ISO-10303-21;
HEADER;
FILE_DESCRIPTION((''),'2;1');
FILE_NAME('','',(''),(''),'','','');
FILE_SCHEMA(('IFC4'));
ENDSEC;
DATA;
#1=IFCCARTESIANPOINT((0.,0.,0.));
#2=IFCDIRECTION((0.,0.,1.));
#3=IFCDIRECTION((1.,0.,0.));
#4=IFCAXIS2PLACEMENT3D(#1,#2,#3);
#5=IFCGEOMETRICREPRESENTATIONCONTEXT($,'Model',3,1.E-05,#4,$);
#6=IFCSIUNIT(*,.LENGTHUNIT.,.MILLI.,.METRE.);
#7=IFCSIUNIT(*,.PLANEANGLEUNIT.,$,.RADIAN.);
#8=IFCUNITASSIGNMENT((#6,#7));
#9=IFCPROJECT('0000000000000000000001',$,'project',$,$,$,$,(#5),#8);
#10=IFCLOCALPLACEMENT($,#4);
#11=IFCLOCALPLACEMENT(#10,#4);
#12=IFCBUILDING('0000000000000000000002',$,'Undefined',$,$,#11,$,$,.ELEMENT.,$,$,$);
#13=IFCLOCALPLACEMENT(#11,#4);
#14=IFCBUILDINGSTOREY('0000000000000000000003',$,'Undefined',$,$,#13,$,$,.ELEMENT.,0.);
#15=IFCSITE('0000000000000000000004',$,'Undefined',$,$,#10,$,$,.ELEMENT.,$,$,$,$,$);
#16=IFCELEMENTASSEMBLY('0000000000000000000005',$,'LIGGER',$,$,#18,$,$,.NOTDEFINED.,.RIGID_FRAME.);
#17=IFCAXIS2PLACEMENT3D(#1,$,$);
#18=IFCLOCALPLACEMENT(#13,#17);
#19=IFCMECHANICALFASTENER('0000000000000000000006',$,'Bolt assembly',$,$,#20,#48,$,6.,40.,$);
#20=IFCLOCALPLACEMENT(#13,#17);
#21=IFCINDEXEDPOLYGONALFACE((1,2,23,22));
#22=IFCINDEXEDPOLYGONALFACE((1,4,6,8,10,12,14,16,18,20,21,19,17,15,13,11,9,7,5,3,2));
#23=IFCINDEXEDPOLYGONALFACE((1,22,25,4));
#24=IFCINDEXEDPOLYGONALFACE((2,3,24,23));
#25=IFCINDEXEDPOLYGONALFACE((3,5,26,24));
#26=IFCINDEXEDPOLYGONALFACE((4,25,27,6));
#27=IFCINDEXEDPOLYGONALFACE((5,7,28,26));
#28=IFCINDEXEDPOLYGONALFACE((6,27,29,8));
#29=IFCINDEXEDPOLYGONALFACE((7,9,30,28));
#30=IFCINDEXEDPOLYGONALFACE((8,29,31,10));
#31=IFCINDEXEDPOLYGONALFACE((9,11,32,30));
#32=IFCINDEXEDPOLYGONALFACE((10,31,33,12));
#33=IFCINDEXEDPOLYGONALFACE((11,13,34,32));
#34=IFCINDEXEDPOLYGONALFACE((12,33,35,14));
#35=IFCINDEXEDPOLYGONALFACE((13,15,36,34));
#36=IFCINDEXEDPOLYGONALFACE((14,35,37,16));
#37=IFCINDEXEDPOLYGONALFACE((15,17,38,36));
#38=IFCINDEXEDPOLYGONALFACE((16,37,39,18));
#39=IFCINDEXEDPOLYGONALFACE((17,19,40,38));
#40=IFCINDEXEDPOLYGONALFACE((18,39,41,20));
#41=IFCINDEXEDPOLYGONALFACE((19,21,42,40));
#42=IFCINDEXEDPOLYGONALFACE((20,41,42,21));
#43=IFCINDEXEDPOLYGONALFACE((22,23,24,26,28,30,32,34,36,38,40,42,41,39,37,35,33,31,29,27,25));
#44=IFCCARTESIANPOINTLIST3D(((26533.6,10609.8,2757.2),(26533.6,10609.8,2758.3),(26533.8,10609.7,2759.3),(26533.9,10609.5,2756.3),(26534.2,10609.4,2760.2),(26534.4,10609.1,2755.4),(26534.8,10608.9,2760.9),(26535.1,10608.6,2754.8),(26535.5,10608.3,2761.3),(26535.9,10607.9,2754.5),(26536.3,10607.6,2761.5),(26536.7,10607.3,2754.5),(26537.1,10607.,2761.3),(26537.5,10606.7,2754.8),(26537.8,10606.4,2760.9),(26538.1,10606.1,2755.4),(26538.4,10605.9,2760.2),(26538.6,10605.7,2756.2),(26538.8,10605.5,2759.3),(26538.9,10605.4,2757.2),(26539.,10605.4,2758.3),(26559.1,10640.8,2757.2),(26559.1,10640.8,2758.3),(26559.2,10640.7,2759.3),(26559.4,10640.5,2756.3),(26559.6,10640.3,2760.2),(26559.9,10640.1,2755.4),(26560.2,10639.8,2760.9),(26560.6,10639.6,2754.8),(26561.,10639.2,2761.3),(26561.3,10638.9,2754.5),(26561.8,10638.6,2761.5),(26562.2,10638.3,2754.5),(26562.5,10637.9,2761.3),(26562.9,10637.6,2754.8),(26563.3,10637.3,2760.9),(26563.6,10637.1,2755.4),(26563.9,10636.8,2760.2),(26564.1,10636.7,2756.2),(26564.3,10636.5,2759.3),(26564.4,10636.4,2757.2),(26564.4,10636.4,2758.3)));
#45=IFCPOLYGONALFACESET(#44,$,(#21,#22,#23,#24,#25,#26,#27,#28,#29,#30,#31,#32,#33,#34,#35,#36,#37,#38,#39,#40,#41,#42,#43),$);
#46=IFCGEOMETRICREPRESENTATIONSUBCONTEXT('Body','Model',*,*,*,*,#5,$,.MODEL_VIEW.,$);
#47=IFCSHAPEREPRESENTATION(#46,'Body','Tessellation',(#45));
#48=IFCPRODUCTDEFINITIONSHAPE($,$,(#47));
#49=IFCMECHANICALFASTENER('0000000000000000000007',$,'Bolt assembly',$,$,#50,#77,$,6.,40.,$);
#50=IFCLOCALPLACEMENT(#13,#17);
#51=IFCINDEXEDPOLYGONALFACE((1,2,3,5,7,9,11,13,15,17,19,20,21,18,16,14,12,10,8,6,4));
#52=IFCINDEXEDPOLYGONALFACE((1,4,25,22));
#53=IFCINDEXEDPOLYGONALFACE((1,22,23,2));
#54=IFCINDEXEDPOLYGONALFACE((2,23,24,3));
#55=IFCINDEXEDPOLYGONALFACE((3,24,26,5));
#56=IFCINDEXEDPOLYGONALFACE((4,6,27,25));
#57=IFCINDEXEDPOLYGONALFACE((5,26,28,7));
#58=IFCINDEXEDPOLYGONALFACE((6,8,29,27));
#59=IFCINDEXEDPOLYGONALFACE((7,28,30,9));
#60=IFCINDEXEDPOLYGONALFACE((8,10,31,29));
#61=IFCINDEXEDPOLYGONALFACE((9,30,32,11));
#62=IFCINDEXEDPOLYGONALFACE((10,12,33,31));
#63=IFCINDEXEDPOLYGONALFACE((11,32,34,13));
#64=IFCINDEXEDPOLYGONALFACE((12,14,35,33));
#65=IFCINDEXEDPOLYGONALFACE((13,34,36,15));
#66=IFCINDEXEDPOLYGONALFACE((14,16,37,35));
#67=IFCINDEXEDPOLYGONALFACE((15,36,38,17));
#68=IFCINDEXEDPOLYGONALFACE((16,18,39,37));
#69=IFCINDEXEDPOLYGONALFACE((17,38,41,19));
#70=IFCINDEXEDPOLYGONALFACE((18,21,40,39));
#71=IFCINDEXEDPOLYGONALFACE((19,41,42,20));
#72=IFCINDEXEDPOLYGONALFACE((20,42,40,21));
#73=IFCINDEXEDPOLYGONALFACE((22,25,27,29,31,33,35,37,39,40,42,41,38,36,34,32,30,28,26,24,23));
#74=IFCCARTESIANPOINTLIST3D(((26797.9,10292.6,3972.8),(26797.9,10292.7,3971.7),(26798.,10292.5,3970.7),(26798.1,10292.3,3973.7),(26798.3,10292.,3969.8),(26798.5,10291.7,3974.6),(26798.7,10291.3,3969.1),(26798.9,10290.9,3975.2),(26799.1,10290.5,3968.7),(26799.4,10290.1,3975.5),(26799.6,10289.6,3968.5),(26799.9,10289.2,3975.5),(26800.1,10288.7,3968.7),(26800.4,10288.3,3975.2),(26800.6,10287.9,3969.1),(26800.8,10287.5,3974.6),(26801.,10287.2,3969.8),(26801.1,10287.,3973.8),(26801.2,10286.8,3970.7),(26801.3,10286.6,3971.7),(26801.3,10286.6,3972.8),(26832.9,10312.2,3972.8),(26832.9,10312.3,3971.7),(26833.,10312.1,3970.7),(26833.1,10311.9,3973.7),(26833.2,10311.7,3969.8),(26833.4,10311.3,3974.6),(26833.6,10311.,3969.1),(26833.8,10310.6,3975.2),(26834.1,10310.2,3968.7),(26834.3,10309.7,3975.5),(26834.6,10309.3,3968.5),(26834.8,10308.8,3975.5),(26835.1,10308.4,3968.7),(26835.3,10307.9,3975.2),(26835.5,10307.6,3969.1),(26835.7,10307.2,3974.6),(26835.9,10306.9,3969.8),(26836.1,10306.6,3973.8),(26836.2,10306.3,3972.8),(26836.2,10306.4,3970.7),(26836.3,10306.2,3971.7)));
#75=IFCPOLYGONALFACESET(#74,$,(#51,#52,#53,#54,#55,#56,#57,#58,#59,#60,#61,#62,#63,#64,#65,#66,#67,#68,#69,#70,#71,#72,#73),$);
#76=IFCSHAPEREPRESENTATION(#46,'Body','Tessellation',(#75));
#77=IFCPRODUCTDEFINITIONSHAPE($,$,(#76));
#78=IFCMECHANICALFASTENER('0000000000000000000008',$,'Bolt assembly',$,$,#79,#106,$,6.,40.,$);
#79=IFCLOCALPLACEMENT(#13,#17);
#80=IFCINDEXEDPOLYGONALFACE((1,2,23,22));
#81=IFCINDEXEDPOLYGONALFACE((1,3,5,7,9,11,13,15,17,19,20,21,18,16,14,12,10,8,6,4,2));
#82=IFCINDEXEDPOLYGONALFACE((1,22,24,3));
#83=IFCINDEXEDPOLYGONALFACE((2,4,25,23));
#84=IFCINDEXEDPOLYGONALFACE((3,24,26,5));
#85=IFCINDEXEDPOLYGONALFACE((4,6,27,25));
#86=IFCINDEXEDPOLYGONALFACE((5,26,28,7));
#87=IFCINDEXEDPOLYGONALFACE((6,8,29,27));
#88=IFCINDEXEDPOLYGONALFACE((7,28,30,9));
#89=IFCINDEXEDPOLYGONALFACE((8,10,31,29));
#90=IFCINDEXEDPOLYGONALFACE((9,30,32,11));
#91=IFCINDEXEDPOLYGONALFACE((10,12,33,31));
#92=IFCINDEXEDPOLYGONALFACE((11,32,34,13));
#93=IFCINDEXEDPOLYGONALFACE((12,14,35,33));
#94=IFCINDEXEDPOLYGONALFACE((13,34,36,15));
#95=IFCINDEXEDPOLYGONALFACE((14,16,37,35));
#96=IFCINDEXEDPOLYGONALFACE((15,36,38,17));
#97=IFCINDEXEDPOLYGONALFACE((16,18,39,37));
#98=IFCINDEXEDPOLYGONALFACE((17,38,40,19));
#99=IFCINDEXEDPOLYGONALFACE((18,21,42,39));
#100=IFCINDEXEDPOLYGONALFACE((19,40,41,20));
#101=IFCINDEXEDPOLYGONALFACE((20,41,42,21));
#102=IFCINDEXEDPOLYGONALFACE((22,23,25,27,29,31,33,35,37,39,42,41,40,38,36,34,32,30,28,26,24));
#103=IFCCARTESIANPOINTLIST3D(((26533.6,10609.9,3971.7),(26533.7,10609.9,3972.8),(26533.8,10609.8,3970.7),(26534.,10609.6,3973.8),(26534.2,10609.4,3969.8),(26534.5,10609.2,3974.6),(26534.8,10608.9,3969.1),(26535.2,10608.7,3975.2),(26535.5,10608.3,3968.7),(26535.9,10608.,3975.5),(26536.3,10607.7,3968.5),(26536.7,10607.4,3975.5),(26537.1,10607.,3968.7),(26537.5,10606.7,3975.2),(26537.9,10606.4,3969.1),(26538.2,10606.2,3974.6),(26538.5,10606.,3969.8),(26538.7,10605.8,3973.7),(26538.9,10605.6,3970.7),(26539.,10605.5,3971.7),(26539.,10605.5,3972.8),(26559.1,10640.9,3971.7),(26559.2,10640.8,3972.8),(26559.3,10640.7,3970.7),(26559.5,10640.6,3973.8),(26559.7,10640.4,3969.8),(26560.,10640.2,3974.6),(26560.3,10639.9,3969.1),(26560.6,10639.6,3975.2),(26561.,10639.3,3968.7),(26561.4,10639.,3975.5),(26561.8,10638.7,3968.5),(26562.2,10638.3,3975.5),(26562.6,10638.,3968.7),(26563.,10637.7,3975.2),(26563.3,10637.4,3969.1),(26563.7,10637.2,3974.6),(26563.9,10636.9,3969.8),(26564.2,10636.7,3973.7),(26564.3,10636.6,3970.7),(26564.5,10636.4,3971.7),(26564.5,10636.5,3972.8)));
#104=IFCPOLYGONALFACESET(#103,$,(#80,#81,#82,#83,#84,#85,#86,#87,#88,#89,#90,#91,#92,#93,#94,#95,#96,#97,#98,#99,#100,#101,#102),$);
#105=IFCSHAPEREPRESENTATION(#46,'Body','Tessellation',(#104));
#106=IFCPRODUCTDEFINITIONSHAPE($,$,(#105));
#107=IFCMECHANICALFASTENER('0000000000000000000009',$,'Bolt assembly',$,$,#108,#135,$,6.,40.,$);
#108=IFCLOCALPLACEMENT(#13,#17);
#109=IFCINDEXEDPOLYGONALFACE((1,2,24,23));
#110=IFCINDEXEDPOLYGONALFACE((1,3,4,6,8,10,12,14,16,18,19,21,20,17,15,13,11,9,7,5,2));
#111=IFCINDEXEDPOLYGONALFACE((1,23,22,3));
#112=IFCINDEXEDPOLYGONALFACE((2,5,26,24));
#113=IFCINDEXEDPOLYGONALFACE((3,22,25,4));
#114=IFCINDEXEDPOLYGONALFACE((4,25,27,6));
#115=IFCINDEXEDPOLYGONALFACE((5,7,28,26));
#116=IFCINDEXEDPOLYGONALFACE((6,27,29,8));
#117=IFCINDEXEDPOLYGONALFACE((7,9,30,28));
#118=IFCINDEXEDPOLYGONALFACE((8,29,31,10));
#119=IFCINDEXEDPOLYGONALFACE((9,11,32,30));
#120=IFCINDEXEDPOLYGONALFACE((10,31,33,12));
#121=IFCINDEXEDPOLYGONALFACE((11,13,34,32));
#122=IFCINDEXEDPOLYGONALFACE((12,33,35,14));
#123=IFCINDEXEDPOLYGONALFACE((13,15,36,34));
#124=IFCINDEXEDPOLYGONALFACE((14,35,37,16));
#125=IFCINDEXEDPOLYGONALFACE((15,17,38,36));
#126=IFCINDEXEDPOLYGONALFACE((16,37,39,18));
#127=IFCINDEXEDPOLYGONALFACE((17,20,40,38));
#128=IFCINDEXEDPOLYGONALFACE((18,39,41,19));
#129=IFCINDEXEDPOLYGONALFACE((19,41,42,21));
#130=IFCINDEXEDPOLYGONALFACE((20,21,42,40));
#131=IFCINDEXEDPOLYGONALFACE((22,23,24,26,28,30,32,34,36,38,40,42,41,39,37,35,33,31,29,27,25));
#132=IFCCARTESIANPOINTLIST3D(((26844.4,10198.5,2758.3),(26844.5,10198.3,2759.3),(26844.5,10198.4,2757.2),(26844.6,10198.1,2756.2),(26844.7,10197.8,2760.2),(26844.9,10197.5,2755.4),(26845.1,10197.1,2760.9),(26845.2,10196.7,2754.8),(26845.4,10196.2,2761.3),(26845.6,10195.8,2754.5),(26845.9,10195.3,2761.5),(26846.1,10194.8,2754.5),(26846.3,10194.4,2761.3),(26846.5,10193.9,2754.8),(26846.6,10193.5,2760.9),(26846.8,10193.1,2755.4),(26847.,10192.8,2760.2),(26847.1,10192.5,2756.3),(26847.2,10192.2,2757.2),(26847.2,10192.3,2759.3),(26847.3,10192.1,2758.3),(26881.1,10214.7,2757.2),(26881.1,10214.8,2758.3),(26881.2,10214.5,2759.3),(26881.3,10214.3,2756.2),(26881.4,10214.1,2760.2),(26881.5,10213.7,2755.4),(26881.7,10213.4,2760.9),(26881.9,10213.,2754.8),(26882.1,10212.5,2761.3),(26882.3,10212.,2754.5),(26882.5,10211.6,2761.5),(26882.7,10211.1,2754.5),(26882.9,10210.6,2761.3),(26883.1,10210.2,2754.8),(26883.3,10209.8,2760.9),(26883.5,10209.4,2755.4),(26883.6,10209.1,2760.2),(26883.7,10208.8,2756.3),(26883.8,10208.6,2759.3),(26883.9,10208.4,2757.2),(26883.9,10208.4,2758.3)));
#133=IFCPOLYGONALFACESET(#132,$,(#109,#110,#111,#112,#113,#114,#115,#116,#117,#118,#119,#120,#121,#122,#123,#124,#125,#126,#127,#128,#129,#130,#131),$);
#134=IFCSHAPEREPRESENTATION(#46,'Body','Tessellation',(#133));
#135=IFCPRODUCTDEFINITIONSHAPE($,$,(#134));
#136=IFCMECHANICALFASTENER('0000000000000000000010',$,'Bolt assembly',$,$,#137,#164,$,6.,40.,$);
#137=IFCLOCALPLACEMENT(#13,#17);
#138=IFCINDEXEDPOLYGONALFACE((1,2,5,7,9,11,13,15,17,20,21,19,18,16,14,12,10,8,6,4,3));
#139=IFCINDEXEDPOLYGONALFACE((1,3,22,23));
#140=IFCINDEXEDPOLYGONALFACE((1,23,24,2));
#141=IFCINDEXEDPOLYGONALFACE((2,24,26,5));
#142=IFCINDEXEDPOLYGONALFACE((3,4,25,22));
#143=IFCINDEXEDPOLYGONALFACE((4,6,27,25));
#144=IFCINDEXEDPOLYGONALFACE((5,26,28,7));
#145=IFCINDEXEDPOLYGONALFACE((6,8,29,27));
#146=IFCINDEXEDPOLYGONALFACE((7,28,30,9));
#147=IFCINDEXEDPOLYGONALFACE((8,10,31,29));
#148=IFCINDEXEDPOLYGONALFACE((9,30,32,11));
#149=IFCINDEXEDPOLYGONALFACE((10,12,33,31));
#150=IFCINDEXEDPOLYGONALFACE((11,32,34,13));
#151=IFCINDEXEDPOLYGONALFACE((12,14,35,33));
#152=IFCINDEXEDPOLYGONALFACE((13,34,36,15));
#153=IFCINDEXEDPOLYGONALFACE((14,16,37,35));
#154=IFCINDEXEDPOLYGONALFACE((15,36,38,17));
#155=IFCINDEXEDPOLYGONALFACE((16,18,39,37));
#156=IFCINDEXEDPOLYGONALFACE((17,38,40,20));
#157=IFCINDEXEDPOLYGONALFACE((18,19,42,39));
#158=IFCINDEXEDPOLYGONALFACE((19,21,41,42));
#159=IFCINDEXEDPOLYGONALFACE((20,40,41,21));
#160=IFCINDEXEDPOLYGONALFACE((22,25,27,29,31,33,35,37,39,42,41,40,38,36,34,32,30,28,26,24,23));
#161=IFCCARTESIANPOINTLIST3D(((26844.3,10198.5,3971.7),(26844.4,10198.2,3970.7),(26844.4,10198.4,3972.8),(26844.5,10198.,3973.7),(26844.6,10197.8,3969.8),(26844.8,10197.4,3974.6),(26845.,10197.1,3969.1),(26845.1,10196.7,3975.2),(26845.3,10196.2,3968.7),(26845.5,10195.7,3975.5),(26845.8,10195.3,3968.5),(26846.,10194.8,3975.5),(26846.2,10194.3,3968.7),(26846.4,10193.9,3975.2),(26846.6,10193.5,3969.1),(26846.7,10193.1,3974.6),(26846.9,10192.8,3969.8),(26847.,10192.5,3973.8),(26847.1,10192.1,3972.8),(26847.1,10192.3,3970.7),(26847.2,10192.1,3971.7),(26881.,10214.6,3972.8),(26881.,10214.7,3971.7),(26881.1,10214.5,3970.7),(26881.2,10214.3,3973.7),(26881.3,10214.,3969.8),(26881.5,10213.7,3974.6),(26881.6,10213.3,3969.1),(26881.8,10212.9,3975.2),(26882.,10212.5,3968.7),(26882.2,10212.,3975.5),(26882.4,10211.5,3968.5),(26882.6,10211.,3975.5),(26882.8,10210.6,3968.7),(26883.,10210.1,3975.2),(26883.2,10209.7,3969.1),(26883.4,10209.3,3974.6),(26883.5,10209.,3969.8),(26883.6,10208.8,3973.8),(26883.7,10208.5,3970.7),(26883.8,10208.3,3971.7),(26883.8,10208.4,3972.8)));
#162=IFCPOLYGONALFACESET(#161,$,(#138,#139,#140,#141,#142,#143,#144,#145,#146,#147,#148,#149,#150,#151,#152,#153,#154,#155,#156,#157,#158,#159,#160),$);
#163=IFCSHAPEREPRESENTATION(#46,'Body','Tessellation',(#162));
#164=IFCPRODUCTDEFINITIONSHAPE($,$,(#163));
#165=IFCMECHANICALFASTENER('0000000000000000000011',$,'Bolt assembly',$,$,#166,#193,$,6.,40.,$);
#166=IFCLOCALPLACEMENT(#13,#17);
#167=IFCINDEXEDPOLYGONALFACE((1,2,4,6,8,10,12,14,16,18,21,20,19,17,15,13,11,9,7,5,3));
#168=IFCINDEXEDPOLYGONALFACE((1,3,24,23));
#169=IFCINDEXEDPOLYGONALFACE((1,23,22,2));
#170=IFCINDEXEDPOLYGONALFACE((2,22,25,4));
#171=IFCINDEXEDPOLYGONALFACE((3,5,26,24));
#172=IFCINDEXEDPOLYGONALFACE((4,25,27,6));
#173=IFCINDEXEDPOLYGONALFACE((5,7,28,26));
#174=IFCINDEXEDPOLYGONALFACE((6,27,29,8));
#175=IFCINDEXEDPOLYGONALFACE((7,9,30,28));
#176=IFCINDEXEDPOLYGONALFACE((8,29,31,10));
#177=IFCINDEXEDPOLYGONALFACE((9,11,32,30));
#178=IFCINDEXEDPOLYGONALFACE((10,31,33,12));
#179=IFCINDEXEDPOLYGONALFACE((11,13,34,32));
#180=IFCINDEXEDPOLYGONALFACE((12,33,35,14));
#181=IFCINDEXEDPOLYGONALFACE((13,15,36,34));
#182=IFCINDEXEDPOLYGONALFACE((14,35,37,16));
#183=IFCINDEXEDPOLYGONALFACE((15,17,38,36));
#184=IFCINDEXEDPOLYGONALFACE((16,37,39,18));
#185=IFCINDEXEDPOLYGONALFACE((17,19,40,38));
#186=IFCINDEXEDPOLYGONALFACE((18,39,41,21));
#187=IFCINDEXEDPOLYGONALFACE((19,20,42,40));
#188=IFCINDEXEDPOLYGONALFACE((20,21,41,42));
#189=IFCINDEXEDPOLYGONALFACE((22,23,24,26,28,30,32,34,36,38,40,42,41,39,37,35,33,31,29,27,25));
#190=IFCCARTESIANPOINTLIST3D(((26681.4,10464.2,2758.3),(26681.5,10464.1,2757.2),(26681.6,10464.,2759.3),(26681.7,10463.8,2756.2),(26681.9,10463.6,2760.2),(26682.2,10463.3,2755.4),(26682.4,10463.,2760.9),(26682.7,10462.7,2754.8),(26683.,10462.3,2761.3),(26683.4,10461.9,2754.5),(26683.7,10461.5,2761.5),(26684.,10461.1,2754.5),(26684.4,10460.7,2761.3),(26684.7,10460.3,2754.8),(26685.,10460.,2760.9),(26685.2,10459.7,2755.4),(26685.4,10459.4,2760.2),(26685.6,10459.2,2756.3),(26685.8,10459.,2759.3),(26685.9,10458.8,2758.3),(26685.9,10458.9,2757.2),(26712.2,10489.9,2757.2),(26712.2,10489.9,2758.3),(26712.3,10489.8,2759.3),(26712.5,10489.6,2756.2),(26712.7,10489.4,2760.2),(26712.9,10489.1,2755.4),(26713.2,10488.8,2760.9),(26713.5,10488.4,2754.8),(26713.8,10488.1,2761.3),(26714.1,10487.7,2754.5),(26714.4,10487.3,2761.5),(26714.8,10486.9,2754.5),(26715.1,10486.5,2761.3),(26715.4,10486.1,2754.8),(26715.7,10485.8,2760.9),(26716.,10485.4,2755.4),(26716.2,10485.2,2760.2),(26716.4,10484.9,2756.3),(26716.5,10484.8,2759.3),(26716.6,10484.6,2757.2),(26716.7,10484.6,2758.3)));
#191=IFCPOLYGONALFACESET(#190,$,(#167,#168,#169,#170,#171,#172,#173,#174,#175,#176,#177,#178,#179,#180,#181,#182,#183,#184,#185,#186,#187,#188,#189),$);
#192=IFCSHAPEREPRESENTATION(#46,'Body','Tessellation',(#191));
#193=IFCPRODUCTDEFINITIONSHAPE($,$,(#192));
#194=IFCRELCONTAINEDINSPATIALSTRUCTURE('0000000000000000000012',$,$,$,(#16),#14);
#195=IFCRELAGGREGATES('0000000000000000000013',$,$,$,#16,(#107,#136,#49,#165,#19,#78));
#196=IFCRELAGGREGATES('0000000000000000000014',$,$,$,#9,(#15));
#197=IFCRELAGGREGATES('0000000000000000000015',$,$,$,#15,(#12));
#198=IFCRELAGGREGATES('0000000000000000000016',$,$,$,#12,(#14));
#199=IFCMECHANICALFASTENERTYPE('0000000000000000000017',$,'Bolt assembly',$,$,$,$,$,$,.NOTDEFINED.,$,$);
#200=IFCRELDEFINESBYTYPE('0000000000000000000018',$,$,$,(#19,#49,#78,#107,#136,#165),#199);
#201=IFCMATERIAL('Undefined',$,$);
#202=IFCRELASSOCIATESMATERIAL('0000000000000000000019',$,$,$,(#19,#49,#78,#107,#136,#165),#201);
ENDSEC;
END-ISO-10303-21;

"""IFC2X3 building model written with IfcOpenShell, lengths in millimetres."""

from ifc_helpers import new_model, si_unit, frame, origin_with_axes, origin_2d_with_axis, place, context, subcontext, project, spatial, circle, extrude, source, transform, mapped, material, type_object, element, aggregate, save


model = new_model("IFC2X3")

# Units and contexts
model_context = context("Model", 3, precision=1e-05, world=origin_with_axes())
body_context = subcontext(model_context, "Body", "Model", "MODEL_VIEW")
ifc_project = project(units=[si_unit("LENGTHUNIT", "METRE", prefix="MILLI"), si_unit("PLANEANGLEUNIT", "RADIAN")], contexts=[model_context])

# Site, building, storey
site_placement = place(None, origin_with_axes())
site = spatial("IfcSite", under=ifc_project, at=site_placement, Name="Undefined", CompositionType="ELEMENT")
building_placement = place(site_placement, origin_with_axes())
building = spatial("IfcBuilding", under=site, at=building_placement, Name="Undefined", CompositionType="ELEMENT")
storey_placement = place(building_placement, origin_with_axes())
storey = spatial("IfcBuildingStorey", under=building, at=storey_placement, Name="Undefined", CompositionType="ELEMENT", Elevation=0.0)

# Element assembly
assembly_1_placement = place(storey_placement, origin_with_axes())
assembly_1 = element("IfcElementAssembly", 1, at=assembly_1_placement, inside=storey, Name="LIGGER", AssemblyPlace="NOTDEFINED", PredefinedType="RIGID_FRAME")

# Mechanical fasteners
ifc_material_1 = material(Name="Undefined")
mechanical_fastener_type = type_object("IfcMechanicalFastenerType", Name="Bolt assembly")
shared_shape_1 = source(origin_with_axes(), body_context, "Body", "SweptSolid", [
    extrude(circle(Radius=3.5, at=origin_2d_with_axis()), frame((0.0, 0.0, 0.0), z_axis=(0.0, 1.0, 0.0), x_axis=(1.0, 0.0, 0.0)), (0.0, 0.0, 1.0), 40.1),
])
mechanical_fastener_1_placement = place(assembly_1_placement, frame((26561.8, 10638.6, 2758.0), z_axis=(0.772296, -0.635263, 0.0), x_axis=(0.0, 0.0, 1.0)))
mechanical_fastener_1 = element("IfcMechanicalFastener", 2, at=mechanical_fastener_1_placement, type_object=mechanical_fastener_type, material=ifc_material_1, Name="Bolt assembly", NominalDiameter=6.0, NominalLength=40.0, context=body_context, shape_type="MappedRepresentation", body=[
    mapped(shared_shape_1, transform((0.0, 0.0, 0.0))),
])
shared_shape_2 = source(origin_with_axes(), body_context, "Body", "SweptSolid", [
    extrude(circle(Radius=3.5, at=origin_2d_with_axis()), frame((0.0, -40.0, 0.0), z_axis=(0.0, 1.0, 0.0), x_axis=(1.0, 0.0, 0.0)), (0.0, 0.0, 1.0), 40.1),
])
mechanical_fastener_2_placement = place(assembly_1_placement, frame((26799.7, 10289.7, 3972.0), z_axis=(-0.490275, 0.871568, 0.0), x_axis=(0.0, 0.0, -1.0)))
mechanical_fastener_2 = element("IfcMechanicalFastener", 3, at=mechanical_fastener_2_placement, type_object=mechanical_fastener_type, material=ifc_material_1, Name="Bolt assembly", NominalDiameter=6.0, NominalLength=40.0, context=body_context, shape_type="MappedRepresentation", body=[
    mapped(shared_shape_2, transform((0.0, 0.0, 0.0))),
])
mechanical_fastener_3_placement = place(assembly_1_placement, frame((26561.8, 10638.6, 3972.0), z_axis=(0.772296, -0.635263, 0.0), x_axis=(0.0, 0.0, -1.0)))
mechanical_fastener_3 = element("IfcMechanicalFastener", 4, at=mechanical_fastener_3_placement, type_object=mechanical_fastener_type, material=ifc_material_1, Name="Bolt assembly", NominalDiameter=6.0, NominalLength=40.0, context=body_context, shape_type="MappedRepresentation", body=[
    mapped(shared_shape_2, transform((0.0, 0.0, 0.0))),
])
shared_shape_3 = source(origin_with_axes(), body_context, "Body", "SweptSolid", [
    extrude(circle(Radius=3.5, at=origin_2d_with_axis()), frame((0.0, 1.5, 0.0), z_axis=(0.0, 1.0, 0.0), x_axis=(1.0, 0.0, 0.0)), (0.0, 0.0, 1.0), 40.1),
])
mechanical_fastener_4_placement = place(assembly_1_placement, frame((26844.5, 10194.7, 2758.0), z_axis=(-0.405409, 0.914135, 0.0), x_axis=(0.0, 0.0, 1.0)))
mechanical_fastener_4 = element("IfcMechanicalFastener", 5, at=mechanical_fastener_4_placement, type_object=mechanical_fastener_type, material=ifc_material_1, Name="Bolt assembly", NominalDiameter=6.0, NominalLength=40.0, context=body_context, shape_type="MappedRepresentation", body=[
    mapped(shared_shape_3, transform((0.0, 0.0, 0.0))),
])
shared_shape_4 = source(origin_with_axes(), body_context, "Body", "SweptSolid", [
    extrude(circle(Radius=3.5, at=origin_2d_with_axis()), frame((0.0, -41.5, 0.0), z_axis=(0.0, 1.0, 0.0), x_axis=(1.0, 0.0, 0.0)), (0.0, 0.0, 1.0), 40.1),
])
mechanical_fastener_5_placement = place(assembly_1_placement, frame((26844.5, 10194.7, 3972.0), z_axis=(-0.405409, 0.914135, 0.0), x_axis=(0.0, 0.0, -1.0)))
mechanical_fastener_5 = element("IfcMechanicalFastener", 6, at=mechanical_fastener_5_placement, type_object=mechanical_fastener_type, material=ifc_material_1, Name="Bolt assembly", NominalDiameter=6.0, NominalLength=40.0, context=body_context, shape_type="MappedRepresentation", body=[
    mapped(shared_shape_4, transform((0.0, 0.0, 0.0))),
])
shared_shape_5 = source(origin_with_axes(), body_context, "Body", "SweptSolid", [
    extrude(circle(Radius=3.5, at=origin_2d_with_axis()), frame((0.0, -17.7, 0.0), z_axis=(0.0, 1.0, 0.0), x_axis=(1.0, 0.0, 0.0)), (0.0, 0.0, 1.0), 40.1),
])
mechanical_fastener_6_placement = place(assembly_1_placement, frame((26697.2, 10472.9, 2758.0), z_axis=(-0.642235, 0.766508, 0.0), x_axis=(0.0, 0.0, 1.0)))
mechanical_fastener_6 = element("IfcMechanicalFastener", 7, at=mechanical_fastener_6_placement, type_object=mechanical_fastener_type, material=ifc_material_1, Name="Bolt assembly", NominalDiameter=6.0, NominalLength=40.0, context=body_context, shape_type="MappedRepresentation", body=[
    mapped(shared_shape_5, transform((0.0, 0.0, 0.0))),
])
aggregate(assembly_1, [mechanical_fastener_4, mechanical_fastener_5, mechanical_fastener_2, mechanical_fastener_6, mechanical_fastener_1, mechanical_fastener_3])

save(model, "model.ifc")
